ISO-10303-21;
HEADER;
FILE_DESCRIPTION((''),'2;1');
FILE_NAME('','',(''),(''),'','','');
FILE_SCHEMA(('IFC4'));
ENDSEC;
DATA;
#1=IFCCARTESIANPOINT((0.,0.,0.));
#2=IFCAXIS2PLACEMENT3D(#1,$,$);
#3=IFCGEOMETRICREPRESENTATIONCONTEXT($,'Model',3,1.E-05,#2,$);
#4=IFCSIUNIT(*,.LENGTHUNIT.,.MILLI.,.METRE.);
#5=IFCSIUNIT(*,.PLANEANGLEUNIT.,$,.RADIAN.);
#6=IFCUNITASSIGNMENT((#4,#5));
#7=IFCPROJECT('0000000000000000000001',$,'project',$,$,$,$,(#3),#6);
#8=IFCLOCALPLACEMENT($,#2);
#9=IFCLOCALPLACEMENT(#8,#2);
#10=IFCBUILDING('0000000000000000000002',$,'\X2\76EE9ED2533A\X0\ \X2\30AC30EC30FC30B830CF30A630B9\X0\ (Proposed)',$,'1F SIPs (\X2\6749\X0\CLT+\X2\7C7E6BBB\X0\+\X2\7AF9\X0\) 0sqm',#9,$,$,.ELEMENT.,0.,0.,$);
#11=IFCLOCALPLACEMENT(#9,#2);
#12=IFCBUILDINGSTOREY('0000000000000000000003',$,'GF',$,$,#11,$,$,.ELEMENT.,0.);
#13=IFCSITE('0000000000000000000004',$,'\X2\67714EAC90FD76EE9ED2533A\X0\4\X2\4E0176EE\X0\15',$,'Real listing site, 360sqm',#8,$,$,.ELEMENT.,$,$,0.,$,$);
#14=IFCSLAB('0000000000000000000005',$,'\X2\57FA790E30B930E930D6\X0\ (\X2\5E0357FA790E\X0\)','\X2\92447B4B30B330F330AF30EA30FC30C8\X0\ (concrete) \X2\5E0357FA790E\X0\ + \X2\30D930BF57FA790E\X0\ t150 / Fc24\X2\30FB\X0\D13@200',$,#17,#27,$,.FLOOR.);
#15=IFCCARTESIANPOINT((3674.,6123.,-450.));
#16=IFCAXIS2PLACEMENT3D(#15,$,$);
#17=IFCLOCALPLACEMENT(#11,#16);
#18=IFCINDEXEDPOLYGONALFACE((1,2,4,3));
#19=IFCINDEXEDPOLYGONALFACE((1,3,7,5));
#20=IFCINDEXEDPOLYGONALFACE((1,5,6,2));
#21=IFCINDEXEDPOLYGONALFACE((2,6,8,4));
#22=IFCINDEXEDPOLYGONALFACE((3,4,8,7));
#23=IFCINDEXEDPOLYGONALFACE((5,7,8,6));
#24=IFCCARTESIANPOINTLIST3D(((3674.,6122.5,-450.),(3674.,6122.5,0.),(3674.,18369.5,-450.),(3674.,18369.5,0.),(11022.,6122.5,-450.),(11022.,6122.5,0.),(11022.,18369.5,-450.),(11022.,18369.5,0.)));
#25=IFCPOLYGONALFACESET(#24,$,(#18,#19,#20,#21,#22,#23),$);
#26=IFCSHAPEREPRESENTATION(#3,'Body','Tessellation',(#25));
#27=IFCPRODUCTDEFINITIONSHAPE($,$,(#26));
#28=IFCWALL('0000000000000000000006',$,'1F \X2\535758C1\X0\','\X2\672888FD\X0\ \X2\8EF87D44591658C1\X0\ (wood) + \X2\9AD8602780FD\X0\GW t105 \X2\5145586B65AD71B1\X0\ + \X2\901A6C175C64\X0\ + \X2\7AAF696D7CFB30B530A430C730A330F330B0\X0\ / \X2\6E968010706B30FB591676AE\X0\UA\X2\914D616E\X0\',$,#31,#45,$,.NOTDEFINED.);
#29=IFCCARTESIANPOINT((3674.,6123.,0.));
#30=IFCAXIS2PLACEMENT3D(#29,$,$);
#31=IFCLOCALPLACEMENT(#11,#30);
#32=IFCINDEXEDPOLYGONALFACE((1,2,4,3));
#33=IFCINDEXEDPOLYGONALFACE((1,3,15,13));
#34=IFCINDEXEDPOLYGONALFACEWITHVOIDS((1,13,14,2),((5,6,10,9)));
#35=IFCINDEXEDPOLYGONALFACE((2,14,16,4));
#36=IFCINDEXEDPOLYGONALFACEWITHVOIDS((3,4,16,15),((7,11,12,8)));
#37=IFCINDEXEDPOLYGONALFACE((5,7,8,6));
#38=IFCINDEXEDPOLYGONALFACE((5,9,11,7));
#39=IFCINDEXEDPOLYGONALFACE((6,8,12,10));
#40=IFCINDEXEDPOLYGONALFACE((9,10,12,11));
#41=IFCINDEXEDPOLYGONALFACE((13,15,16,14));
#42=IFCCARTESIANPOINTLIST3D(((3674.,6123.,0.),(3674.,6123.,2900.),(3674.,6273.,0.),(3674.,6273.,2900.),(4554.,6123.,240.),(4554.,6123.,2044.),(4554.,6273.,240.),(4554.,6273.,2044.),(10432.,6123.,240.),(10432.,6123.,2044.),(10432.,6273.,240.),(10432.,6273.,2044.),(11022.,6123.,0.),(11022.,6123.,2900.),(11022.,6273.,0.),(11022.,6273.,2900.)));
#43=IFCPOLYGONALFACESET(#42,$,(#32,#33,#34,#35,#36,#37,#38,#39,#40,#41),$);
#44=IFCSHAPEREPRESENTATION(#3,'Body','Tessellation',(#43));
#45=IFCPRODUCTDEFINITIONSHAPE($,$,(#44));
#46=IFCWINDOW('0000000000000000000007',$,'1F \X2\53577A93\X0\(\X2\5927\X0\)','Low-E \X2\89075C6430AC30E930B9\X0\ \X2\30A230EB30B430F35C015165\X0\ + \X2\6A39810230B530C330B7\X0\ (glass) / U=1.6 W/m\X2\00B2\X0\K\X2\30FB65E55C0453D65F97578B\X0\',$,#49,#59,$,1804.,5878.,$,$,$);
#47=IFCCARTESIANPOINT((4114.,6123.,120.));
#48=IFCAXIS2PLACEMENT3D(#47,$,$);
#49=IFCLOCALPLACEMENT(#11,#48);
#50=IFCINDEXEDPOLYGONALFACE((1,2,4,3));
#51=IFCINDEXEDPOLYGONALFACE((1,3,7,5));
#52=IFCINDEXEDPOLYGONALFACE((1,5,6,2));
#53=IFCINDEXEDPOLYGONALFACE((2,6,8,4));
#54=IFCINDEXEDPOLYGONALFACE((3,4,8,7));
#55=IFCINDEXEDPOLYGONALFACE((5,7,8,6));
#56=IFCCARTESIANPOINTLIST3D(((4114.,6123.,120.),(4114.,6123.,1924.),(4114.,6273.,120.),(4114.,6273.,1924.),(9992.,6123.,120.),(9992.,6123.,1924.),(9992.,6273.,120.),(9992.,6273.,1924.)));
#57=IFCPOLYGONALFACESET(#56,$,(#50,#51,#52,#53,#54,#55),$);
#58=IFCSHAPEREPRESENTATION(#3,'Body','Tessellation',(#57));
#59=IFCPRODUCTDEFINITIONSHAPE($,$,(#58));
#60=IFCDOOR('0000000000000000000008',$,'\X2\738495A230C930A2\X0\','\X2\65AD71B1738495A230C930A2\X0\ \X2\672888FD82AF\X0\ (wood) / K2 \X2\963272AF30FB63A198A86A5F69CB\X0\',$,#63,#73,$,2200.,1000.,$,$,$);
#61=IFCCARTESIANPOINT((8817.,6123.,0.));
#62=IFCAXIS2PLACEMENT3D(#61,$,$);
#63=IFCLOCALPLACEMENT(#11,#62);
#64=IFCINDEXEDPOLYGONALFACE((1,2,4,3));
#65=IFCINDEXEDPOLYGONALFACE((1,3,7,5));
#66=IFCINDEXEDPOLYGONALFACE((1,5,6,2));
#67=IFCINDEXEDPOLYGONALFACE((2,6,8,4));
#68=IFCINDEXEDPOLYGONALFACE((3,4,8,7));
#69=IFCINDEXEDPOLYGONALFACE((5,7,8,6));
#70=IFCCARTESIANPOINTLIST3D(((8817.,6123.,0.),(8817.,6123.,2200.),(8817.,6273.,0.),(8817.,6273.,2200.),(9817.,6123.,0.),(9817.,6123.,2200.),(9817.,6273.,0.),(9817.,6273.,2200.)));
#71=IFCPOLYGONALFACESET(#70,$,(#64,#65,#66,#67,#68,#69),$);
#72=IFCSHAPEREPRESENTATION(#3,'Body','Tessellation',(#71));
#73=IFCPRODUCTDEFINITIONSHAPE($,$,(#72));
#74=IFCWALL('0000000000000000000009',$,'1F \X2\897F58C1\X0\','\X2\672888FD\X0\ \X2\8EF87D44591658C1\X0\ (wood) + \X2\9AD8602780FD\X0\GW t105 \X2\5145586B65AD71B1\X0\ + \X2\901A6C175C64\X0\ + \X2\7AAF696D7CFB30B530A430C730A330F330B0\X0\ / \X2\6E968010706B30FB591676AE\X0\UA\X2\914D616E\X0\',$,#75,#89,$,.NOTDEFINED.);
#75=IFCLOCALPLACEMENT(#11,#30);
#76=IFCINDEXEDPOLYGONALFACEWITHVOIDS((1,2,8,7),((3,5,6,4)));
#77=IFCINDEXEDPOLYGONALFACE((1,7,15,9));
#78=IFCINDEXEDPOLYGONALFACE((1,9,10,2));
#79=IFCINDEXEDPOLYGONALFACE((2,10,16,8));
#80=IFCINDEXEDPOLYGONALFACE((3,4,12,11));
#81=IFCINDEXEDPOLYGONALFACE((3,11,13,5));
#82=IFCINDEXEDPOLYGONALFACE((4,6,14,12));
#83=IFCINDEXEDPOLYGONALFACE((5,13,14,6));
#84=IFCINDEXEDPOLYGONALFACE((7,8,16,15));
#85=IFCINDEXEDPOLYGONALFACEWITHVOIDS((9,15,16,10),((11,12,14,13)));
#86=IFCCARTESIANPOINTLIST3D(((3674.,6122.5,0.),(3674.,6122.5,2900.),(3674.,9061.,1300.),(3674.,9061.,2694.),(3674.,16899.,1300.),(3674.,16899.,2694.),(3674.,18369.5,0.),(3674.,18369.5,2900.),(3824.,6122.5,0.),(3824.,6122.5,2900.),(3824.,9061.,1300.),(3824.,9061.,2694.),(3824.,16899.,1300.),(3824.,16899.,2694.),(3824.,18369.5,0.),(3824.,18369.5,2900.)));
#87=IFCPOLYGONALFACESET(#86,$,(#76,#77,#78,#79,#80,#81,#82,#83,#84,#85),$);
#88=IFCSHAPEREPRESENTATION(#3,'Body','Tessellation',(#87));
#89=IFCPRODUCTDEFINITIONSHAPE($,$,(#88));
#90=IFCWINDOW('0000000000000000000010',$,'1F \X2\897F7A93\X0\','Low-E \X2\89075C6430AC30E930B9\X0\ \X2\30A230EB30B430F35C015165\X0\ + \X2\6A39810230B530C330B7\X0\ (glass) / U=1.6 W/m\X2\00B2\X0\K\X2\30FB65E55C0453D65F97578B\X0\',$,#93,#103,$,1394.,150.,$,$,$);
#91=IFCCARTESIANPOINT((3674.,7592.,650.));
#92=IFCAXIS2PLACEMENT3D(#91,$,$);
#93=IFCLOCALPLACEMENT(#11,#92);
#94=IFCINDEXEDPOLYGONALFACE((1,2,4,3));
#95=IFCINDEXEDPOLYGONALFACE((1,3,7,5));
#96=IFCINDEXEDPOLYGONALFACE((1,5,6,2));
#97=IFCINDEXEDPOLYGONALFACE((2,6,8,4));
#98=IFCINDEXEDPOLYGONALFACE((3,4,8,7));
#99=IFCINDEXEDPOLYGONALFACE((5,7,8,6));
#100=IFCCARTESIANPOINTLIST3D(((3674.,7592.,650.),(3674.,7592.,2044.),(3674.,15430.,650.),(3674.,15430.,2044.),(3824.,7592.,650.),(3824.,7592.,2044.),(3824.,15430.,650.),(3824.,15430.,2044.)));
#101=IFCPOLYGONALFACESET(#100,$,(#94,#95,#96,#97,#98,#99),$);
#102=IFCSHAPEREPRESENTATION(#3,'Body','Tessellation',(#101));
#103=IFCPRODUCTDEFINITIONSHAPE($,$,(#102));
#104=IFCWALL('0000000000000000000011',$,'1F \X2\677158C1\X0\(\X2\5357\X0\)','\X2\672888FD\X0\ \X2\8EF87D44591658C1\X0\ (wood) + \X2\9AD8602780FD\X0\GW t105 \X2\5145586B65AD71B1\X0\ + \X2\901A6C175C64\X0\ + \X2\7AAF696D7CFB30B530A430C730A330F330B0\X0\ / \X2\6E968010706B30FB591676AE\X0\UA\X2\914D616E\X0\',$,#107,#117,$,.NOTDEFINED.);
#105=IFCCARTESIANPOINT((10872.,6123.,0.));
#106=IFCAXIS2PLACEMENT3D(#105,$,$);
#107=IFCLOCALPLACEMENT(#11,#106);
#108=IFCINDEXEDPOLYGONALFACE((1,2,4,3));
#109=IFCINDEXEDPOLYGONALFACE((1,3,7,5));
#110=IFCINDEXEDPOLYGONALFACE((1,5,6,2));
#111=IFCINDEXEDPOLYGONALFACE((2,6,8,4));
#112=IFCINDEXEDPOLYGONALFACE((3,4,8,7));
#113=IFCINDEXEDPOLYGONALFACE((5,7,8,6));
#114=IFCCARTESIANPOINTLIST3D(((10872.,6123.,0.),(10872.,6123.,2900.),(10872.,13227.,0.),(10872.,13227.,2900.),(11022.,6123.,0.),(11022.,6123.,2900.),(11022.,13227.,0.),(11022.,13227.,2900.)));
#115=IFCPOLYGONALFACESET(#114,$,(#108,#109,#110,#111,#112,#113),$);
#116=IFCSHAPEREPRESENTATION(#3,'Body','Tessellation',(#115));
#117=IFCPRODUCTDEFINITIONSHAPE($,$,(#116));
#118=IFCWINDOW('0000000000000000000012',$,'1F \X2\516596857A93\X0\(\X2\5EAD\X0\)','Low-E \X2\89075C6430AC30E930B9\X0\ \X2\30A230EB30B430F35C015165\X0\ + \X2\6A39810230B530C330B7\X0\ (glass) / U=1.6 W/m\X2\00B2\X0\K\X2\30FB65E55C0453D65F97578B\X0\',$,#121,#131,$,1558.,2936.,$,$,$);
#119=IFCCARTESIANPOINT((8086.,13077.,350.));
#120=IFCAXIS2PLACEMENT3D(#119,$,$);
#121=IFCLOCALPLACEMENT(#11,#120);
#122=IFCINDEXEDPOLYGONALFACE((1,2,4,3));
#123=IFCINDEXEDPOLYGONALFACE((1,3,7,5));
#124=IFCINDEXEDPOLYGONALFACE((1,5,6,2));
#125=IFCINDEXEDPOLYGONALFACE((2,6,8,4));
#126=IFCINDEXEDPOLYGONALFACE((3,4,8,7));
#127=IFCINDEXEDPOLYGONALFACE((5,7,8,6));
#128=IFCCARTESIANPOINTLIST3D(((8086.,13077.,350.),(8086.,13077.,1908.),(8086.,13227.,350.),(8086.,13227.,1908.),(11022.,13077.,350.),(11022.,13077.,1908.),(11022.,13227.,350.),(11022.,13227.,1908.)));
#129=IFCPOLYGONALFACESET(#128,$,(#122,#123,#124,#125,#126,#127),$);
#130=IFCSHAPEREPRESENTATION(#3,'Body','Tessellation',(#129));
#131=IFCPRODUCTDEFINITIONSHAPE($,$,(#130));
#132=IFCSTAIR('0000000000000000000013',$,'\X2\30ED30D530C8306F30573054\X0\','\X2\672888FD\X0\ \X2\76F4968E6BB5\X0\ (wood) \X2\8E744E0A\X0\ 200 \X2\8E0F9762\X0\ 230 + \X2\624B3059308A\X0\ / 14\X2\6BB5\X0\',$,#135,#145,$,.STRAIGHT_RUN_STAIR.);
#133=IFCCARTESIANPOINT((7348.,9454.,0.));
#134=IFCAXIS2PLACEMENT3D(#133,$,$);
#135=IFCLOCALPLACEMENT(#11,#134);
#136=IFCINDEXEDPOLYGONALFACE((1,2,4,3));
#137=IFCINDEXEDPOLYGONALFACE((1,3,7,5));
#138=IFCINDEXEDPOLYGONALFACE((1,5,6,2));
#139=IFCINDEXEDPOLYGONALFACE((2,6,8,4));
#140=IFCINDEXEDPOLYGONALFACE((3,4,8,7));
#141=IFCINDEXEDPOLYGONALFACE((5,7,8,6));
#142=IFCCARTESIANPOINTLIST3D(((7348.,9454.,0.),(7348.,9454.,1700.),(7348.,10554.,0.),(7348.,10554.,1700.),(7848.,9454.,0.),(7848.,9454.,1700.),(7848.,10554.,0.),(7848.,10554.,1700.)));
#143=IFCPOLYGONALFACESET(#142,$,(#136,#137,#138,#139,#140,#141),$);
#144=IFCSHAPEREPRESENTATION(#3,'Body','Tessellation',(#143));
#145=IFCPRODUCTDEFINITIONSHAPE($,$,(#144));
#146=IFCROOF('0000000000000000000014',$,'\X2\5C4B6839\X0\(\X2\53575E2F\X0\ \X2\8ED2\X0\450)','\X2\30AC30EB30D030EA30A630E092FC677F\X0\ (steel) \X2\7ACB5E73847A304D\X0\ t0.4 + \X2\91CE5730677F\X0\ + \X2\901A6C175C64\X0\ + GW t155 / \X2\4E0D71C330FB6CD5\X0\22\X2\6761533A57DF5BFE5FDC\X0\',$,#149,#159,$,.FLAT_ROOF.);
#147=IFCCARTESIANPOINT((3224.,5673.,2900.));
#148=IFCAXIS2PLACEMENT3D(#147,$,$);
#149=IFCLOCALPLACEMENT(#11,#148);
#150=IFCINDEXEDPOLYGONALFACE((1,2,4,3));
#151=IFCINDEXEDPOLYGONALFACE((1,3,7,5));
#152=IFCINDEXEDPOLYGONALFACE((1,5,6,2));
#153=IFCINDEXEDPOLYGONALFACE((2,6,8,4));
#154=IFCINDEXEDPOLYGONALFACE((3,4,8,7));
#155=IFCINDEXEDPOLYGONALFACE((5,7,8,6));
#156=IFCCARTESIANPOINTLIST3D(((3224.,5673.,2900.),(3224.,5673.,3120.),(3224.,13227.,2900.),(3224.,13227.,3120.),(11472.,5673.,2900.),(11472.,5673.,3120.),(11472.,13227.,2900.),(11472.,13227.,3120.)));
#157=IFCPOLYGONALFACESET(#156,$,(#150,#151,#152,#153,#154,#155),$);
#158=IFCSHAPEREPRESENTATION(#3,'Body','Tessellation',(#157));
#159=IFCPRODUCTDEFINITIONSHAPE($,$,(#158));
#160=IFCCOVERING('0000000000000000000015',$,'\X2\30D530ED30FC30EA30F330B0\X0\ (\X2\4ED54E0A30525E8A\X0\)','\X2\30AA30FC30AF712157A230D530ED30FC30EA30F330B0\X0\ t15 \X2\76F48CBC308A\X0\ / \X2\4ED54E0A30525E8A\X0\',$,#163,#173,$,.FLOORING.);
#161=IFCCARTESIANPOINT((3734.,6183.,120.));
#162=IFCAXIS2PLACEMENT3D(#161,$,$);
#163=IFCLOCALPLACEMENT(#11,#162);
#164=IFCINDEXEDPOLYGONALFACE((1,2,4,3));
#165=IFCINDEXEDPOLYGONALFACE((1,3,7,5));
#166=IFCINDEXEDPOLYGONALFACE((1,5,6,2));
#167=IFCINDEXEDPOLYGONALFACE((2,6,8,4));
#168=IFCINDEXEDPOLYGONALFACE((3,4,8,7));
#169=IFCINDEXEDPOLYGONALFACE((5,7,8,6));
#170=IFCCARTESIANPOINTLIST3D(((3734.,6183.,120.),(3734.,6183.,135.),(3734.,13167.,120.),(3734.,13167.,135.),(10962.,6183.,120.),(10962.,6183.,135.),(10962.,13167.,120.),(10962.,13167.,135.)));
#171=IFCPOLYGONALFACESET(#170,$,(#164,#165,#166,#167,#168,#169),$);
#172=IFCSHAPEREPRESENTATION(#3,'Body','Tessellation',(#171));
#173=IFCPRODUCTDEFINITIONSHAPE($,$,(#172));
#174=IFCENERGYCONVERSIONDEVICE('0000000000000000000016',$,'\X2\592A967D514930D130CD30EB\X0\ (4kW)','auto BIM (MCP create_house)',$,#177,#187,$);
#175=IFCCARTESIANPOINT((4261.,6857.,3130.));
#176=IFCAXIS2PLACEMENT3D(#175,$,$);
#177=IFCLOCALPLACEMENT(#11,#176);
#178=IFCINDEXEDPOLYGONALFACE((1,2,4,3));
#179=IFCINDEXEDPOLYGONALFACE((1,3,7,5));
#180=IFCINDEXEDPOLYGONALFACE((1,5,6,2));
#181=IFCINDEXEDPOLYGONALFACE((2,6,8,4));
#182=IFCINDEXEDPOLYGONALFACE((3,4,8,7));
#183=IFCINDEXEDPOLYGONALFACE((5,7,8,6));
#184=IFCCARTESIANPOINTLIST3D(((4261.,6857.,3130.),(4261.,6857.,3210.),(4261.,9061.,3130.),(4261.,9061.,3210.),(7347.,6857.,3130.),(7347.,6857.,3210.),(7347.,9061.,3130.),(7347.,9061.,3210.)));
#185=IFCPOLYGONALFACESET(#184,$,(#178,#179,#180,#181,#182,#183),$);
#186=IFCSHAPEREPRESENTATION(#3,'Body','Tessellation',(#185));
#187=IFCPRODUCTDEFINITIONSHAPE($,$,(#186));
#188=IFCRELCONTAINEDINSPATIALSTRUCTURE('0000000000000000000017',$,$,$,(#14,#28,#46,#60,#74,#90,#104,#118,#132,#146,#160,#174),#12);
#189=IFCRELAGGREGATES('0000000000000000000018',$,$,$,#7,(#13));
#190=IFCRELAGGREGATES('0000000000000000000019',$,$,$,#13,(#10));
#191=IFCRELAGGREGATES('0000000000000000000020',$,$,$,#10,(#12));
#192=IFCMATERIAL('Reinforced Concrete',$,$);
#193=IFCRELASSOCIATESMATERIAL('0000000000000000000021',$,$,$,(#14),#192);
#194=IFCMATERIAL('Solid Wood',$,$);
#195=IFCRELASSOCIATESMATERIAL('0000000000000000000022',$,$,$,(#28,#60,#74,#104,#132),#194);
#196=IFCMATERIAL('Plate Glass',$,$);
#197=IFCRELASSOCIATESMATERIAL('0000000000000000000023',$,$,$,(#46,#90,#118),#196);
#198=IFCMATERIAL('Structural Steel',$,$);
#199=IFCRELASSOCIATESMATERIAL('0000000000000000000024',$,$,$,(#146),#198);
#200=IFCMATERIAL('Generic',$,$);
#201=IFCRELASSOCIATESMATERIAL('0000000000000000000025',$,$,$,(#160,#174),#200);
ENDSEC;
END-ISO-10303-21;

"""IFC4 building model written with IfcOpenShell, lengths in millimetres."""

from ifc_helpers import new_model, si_unit, frame, frame_2d, origin, place, context, project, spatial, rectangle, extrude, material, element, fill, save


model = new_model("IFC4")

# Units and contexts
model_context = context("Model", 3, precision=1e-05, world=origin())
ifc_project = project(units=[si_unit("LENGTHUNIT", "METRE", prefix="MILLI"), si_unit("PLANEANGLEUNIT", "RADIAN")], contexts=[model_context])

# Site, building, storey
site_placement = place(None, origin())
site = spatial("IfcSite", under=ifc_project, at=site_placement, Name="東京都目黒区4丁目15", ObjectType="Real listing site, 360sqm", CompositionType="ELEMENT", RefElevation=0.0)
building_placement = place(site_placement, origin())
building = spatial("IfcBuilding", under=site, at=building_placement, Name="目黒区 ガレージハウス (Proposed)", ObjectType="1F SIPs (杉CLT+籾殻+竹) 0sqm", CompositionType="ELEMENT", ElevationOfRefHeight=0.0, ElevationOfTerrain=0.0)
storey_placement = place(building_placement, origin())
storey = spatial("IfcBuildingStorey", under=building, at=storey_placement, Name="GF", CompositionType="ELEMENT", Elevation=0.0)

# Slab
ifc_material_1 = material(Name="Reinforced Concrete")
slab_1_placement = place(storey_placement, frame((3674.0, 6123.0, -450.0)))
element("IfcSlab", 1, at=slab_1_placement, inside=storey, material=ifc_material_1, Name="基礎スラブ (布基礎)", Description="鉄筋コンクリート (concrete) 布基礎 + ベタ基礎 t150 / Fc24・D13@200", PredefinedType="FLOOR", context=model_context, shape_type="SweptSolid", body=[
    extrude(rectangle(XDim=7348.0, YDim=12247.0, at=frame_2d((3674.0, 6123.0))), frame((3674.0, 6123.0, -450.0)), (0.0, 0.0, 1.0), 450.0),
])
ifc_material_2 = material(Name="Solid Wood")

# Wall, openings, window, door
wall_1_placement = place(storey_placement, frame((3674.0, 6123.0, 0.0)))
wall_1 = element("IfcWall", 2, at=wall_1_placement, inside=storey, material=ifc_material_2, Name="1F 南壁", Description="木製 軸組外壁 (wood) + 高性能GW t105 充填断熱 + 通気層 + 窯業系サイディング / 準耐火・外皮UA配慮", PredefinedType="NOTDEFINED", context=model_context, shape_type="SweptSolid", body=[
    extrude(rectangle(XDim=7348.0, YDim=150.0, at=frame_2d((3674.0, 75.0))), frame((3674.0, 6123.0, 0.0)), (0.0, 0.0, 1.0), 2900.0),
])
opening_1_placement = place(storey_placement, frame((4114.0, 6123.0, 120.0)))
opening_1 = element("IfcOpeningElement", 3, at=opening_1_placement, cuts=wall_1, PredefinedType="NOTDEFINED", context=model_context, shape_type="SweptSolid", body=[
    extrude(rectangle(XDim=5878.0, YDim=150.0, at=frame_2d((2939.0, 75.0))), frame((4114.0, 6123.0, 120.0)), (0.0, 0.0, 1.0), 1804.0),
])
opening_2_placement = place(storey_placement, frame((8817.0, 6123.0, 0.0)))
opening_2 = element("IfcOpeningElement", 4, at=opening_2_placement, cuts=wall_1, PredefinedType="NOTDEFINED", context=model_context, shape_type="SweptSolid", body=[
    extrude(rectangle(XDim=1000.0, YDim=150.0, at=frame_2d((500.0, 75.0))), frame((8817.0, 6123.0, 0.0)), (0.0, 0.0, 1.0), 2200.0),
])
ifc_material_3 = material(Name="Plate Glass")
window_1_placement = place(storey_placement, frame((4114.0, 6123.0, 120.0)))
window_1 = element("IfcWindow", 5, at=window_1_placement, inside=storey, material=ifc_material_3, Name="1F 南窓(大)", Description="Low-E 複層ガラス アルゴン封入 + 樹脂サッシ (glass) / U=1.6 W/m²K・日射取得型", OverallHeight=1804.0, OverallWidth=5878.0, context=model_context, shape_type="SweptSolid", body=[
    extrude(rectangle(XDim=5878.0, YDim=150.0, at=frame_2d((2939.0, 75.0))), frame((4114.0, 6123.0, 120.0)), (0.0, 0.0, 1.0), 1804.0),
])
fill(opening_1, window_1)
door_1_placement = place(storey_placement, frame((8817.0, 6123.0, 0.0)))
door_1 = element("IfcDoor", 6, at=door_1_placement, inside=storey, material=ifc_material_2, Name="玄関ドア", Description="断熱玄関ドア 木製芯 (wood) / K2 防犯・採風機構", OverallHeight=2200.0, OverallWidth=1000.0, context=model_context, shape_type="SweptSolid", body=[
    extrude(rectangle(XDim=1000.0, YDim=150.0, at=frame_2d((500.0, 75.0))), frame((8817.0, 6123.0, 0.0)), (0.0, 0.0, 1.0), 2200.0),
])
fill(opening_2, door_1)

# Walls, openings, windows
wall_2_placement = place(storey_placement, frame((3674.0, 6123.0, 0.0)))
wall_2 = element("IfcWall", 7, at=wall_2_placement, inside=storey, material=ifc_material_2, Name="1F 西壁", Description="木製 軸組外壁 (wood) + 高性能GW t105 充填断熱 + 通気層 + 窯業系サイディング / 準耐火・外皮UA配慮", PredefinedType="NOTDEFINED", context=model_context, shape_type="SweptSolid", body=[
    extrude(rectangle(XDim=150.0, YDim=12247.0, at=frame_2d((75.0, 6123.0))), frame((3674.0, 6123.0, 0.0)), (0.0, 0.0, 1.0), 2900.0),
])
opening_3_placement = place(storey_placement, frame((3674.0, 7592.0, 650.0)))
opening_3 = element("IfcOpeningElement", 8, at=opening_3_placement, cuts=wall_2, PredefinedType="NOTDEFINED", context=model_context, shape_type="SweptSolid", body=[
    extrude(rectangle(XDim=150.0, YDim=7838.0, at=frame_2d((75.0, 3919.0))), frame((3674.0, 7592.0, 650.0)), (0.0, 0.0, 1.0), 1394.0),
])
window_2_placement = place(storey_placement, frame((3674.0, 7592.0, 650.0)))
window_2 = element("IfcWindow", 9, at=window_2_placement, inside=storey, material=ifc_material_3, Name="1F 西窓", Description="Low-E 複層ガラス アルゴン封入 + 樹脂サッシ (glass) / U=1.6 W/m²K・日射取得型", OverallHeight=1394.0, OverallWidth=150.0, context=model_context, shape_type="SweptSolid", body=[
    extrude(rectangle(XDim=150.0, YDim=7838.0, at=frame_2d((75.0, 3919.0))), frame((3674.0, 7592.0, 650.0)), (0.0, 0.0, 1.0), 1394.0),
])
fill(opening_3, window_2)
wall_3_placement = place(storey_placement, frame((10872.0, 6123.0, 0.0)))
wall_3 = element("IfcWall", 10, at=wall_3_placement, inside=storey, material=ifc_material_2, Name="1F 東壁(南)", Description="木製 軸組外壁 (wood) + 高性能GW t105 充填断熱 + 通気層 + 窯業系サイディング / 準耐火・外皮UA配慮", PredefinedType="NOTDEFINED", context=model_context, shape_type="SweptSolid", body=[
    extrude(rectangle(XDim=150.0, YDim=7104.0, at=frame_2d((75.0, 3552.0))), frame((10872.0, 6123.0, 0.0)), (0.0, 0.0, 1.0), 2900.0),
])
opening_4_placement = place(storey_placement, frame((8086.0, 13077.0, 350.0)))
opening_4 = element("IfcOpeningElement", 11, at=opening_4_placement, cuts=wall_3, PredefinedType="NOTDEFINED", context=model_context, shape_type="SweptSolid", body=[
    extrude(rectangle(XDim=2936.0, YDim=150.0, at=frame_2d((1468.0, 75.0))), frame((8086.0, 13077.0, 350.0)), (0.0, 0.0, 1.0), 1558.0),
])
window_3_placement = place(storey_placement, frame((8086.0, 13077.0, 350.0)))
window_3 = element("IfcWindow", 12, at=window_3_placement, inside=storey, material=ifc_material_3, Name="1F 入隅窓(庭)", Description="Low-E 複層ガラス アルゴン封入 + 樹脂サッシ (glass) / U=1.6 W/m²K・日射取得型", OverallHeight=1558.0, OverallWidth=2936.0, context=model_context, shape_type="SweptSolid", body=[
    extrude(rectangle(XDim=2936.0, YDim=150.0, at=frame_2d((1468.0, 75.0))), frame((8086.0, 13077.0, 350.0)), (0.0, 0.0, 1.0), 1558.0),
])
fill(opening_4, window_3)

# Stair
stair_placement = place(storey_placement, frame((7348.0, 9454.0, 0.0)))
element("IfcStair", 13, at=stair_placement, inside=storey, material=ifc_material_2, Name="ロフトはしご", Description="木製 直階段 (wood) 蹴上 200 踏面 230 + 手すり / 14段", PredefinedType="STRAIGHT_RUN_STAIR", context=model_context, shape_type="SweptSolid", body=[
    extrude(rectangle(XDim=500.0, YDim=1100.0, at=frame_2d((250.0, 550.0))), frame((7348.0, 9454.0, 0.0)), (0.0, 0.0, 1.0), 1700.0),
])

# Roof
ifc_material_4 = material(Name="Structural Steel")
roof_placement = place(storey_placement, frame((3224.0, 5673.0, 2900.0)))
element("IfcRoof", 14, at=roof_placement, inside=storey, material=ifc_material_4, Name="屋根(南帯 軒450)", Description="ガルバリウム鋼板 (steel) 立平葺き t0.4 + 野地板 + 通気層 + GW t155 / 不燃・法22条区域対応", PredefinedType="FLAT_ROOF", context=model_context, shape_type="SweptSolid", body=[
    extrude(rectangle(XDim=8248.0, YDim=7554.0, at=frame_2d((4124.0, 3777.0))), frame((3224.0, 5673.0, 2900.0)), (0.0, 0.0, 1.0), 220.0),
])

# Covering
ifc_material_5 = material(Name="Generic")
covering_placement = place(storey_placement, frame((3734.0, 6183.0, 120.0)))
element("IfcCovering", 15, at=covering_placement, inside=storey, material=ifc_material_5, Name="フローリング (仕上げ床)", Description="オーク無垢フローリング t15 直貼り / 仕上げ床", PredefinedType="FLOORING", context=model_context, shape_type="SweptSolid", body=[
    extrude(rectangle(XDim=7228.0, YDim=6984.0, at=frame_2d((3614.0, 3492.0))), frame((3734.0, 6183.0, 120.0)), (0.0, 0.0, 1.0), 15.0),
])

# Energy conversion device
energy_conversion_device_placement = place(storey_placement, frame((4261.0, 6857.0, 3130.0)))
element("IfcEnergyConversionDevice", 16, at=energy_conversion_device_placement, inside=storey, material=ifc_material_5, Name="太陽光パネル (4kW)", Description="auto BIM (MCP create_house)", context=model_context, shape_type="SweptSolid", body=[
    extrude(rectangle(XDim=3086.0, YDim=2204.0, at=frame_2d((1543.0, 1102.0))), frame((4261.0, 6857.0, 3130.0)), (0.0, 0.0, 1.0), 80.0),
])

save(model, "model.ifc")
